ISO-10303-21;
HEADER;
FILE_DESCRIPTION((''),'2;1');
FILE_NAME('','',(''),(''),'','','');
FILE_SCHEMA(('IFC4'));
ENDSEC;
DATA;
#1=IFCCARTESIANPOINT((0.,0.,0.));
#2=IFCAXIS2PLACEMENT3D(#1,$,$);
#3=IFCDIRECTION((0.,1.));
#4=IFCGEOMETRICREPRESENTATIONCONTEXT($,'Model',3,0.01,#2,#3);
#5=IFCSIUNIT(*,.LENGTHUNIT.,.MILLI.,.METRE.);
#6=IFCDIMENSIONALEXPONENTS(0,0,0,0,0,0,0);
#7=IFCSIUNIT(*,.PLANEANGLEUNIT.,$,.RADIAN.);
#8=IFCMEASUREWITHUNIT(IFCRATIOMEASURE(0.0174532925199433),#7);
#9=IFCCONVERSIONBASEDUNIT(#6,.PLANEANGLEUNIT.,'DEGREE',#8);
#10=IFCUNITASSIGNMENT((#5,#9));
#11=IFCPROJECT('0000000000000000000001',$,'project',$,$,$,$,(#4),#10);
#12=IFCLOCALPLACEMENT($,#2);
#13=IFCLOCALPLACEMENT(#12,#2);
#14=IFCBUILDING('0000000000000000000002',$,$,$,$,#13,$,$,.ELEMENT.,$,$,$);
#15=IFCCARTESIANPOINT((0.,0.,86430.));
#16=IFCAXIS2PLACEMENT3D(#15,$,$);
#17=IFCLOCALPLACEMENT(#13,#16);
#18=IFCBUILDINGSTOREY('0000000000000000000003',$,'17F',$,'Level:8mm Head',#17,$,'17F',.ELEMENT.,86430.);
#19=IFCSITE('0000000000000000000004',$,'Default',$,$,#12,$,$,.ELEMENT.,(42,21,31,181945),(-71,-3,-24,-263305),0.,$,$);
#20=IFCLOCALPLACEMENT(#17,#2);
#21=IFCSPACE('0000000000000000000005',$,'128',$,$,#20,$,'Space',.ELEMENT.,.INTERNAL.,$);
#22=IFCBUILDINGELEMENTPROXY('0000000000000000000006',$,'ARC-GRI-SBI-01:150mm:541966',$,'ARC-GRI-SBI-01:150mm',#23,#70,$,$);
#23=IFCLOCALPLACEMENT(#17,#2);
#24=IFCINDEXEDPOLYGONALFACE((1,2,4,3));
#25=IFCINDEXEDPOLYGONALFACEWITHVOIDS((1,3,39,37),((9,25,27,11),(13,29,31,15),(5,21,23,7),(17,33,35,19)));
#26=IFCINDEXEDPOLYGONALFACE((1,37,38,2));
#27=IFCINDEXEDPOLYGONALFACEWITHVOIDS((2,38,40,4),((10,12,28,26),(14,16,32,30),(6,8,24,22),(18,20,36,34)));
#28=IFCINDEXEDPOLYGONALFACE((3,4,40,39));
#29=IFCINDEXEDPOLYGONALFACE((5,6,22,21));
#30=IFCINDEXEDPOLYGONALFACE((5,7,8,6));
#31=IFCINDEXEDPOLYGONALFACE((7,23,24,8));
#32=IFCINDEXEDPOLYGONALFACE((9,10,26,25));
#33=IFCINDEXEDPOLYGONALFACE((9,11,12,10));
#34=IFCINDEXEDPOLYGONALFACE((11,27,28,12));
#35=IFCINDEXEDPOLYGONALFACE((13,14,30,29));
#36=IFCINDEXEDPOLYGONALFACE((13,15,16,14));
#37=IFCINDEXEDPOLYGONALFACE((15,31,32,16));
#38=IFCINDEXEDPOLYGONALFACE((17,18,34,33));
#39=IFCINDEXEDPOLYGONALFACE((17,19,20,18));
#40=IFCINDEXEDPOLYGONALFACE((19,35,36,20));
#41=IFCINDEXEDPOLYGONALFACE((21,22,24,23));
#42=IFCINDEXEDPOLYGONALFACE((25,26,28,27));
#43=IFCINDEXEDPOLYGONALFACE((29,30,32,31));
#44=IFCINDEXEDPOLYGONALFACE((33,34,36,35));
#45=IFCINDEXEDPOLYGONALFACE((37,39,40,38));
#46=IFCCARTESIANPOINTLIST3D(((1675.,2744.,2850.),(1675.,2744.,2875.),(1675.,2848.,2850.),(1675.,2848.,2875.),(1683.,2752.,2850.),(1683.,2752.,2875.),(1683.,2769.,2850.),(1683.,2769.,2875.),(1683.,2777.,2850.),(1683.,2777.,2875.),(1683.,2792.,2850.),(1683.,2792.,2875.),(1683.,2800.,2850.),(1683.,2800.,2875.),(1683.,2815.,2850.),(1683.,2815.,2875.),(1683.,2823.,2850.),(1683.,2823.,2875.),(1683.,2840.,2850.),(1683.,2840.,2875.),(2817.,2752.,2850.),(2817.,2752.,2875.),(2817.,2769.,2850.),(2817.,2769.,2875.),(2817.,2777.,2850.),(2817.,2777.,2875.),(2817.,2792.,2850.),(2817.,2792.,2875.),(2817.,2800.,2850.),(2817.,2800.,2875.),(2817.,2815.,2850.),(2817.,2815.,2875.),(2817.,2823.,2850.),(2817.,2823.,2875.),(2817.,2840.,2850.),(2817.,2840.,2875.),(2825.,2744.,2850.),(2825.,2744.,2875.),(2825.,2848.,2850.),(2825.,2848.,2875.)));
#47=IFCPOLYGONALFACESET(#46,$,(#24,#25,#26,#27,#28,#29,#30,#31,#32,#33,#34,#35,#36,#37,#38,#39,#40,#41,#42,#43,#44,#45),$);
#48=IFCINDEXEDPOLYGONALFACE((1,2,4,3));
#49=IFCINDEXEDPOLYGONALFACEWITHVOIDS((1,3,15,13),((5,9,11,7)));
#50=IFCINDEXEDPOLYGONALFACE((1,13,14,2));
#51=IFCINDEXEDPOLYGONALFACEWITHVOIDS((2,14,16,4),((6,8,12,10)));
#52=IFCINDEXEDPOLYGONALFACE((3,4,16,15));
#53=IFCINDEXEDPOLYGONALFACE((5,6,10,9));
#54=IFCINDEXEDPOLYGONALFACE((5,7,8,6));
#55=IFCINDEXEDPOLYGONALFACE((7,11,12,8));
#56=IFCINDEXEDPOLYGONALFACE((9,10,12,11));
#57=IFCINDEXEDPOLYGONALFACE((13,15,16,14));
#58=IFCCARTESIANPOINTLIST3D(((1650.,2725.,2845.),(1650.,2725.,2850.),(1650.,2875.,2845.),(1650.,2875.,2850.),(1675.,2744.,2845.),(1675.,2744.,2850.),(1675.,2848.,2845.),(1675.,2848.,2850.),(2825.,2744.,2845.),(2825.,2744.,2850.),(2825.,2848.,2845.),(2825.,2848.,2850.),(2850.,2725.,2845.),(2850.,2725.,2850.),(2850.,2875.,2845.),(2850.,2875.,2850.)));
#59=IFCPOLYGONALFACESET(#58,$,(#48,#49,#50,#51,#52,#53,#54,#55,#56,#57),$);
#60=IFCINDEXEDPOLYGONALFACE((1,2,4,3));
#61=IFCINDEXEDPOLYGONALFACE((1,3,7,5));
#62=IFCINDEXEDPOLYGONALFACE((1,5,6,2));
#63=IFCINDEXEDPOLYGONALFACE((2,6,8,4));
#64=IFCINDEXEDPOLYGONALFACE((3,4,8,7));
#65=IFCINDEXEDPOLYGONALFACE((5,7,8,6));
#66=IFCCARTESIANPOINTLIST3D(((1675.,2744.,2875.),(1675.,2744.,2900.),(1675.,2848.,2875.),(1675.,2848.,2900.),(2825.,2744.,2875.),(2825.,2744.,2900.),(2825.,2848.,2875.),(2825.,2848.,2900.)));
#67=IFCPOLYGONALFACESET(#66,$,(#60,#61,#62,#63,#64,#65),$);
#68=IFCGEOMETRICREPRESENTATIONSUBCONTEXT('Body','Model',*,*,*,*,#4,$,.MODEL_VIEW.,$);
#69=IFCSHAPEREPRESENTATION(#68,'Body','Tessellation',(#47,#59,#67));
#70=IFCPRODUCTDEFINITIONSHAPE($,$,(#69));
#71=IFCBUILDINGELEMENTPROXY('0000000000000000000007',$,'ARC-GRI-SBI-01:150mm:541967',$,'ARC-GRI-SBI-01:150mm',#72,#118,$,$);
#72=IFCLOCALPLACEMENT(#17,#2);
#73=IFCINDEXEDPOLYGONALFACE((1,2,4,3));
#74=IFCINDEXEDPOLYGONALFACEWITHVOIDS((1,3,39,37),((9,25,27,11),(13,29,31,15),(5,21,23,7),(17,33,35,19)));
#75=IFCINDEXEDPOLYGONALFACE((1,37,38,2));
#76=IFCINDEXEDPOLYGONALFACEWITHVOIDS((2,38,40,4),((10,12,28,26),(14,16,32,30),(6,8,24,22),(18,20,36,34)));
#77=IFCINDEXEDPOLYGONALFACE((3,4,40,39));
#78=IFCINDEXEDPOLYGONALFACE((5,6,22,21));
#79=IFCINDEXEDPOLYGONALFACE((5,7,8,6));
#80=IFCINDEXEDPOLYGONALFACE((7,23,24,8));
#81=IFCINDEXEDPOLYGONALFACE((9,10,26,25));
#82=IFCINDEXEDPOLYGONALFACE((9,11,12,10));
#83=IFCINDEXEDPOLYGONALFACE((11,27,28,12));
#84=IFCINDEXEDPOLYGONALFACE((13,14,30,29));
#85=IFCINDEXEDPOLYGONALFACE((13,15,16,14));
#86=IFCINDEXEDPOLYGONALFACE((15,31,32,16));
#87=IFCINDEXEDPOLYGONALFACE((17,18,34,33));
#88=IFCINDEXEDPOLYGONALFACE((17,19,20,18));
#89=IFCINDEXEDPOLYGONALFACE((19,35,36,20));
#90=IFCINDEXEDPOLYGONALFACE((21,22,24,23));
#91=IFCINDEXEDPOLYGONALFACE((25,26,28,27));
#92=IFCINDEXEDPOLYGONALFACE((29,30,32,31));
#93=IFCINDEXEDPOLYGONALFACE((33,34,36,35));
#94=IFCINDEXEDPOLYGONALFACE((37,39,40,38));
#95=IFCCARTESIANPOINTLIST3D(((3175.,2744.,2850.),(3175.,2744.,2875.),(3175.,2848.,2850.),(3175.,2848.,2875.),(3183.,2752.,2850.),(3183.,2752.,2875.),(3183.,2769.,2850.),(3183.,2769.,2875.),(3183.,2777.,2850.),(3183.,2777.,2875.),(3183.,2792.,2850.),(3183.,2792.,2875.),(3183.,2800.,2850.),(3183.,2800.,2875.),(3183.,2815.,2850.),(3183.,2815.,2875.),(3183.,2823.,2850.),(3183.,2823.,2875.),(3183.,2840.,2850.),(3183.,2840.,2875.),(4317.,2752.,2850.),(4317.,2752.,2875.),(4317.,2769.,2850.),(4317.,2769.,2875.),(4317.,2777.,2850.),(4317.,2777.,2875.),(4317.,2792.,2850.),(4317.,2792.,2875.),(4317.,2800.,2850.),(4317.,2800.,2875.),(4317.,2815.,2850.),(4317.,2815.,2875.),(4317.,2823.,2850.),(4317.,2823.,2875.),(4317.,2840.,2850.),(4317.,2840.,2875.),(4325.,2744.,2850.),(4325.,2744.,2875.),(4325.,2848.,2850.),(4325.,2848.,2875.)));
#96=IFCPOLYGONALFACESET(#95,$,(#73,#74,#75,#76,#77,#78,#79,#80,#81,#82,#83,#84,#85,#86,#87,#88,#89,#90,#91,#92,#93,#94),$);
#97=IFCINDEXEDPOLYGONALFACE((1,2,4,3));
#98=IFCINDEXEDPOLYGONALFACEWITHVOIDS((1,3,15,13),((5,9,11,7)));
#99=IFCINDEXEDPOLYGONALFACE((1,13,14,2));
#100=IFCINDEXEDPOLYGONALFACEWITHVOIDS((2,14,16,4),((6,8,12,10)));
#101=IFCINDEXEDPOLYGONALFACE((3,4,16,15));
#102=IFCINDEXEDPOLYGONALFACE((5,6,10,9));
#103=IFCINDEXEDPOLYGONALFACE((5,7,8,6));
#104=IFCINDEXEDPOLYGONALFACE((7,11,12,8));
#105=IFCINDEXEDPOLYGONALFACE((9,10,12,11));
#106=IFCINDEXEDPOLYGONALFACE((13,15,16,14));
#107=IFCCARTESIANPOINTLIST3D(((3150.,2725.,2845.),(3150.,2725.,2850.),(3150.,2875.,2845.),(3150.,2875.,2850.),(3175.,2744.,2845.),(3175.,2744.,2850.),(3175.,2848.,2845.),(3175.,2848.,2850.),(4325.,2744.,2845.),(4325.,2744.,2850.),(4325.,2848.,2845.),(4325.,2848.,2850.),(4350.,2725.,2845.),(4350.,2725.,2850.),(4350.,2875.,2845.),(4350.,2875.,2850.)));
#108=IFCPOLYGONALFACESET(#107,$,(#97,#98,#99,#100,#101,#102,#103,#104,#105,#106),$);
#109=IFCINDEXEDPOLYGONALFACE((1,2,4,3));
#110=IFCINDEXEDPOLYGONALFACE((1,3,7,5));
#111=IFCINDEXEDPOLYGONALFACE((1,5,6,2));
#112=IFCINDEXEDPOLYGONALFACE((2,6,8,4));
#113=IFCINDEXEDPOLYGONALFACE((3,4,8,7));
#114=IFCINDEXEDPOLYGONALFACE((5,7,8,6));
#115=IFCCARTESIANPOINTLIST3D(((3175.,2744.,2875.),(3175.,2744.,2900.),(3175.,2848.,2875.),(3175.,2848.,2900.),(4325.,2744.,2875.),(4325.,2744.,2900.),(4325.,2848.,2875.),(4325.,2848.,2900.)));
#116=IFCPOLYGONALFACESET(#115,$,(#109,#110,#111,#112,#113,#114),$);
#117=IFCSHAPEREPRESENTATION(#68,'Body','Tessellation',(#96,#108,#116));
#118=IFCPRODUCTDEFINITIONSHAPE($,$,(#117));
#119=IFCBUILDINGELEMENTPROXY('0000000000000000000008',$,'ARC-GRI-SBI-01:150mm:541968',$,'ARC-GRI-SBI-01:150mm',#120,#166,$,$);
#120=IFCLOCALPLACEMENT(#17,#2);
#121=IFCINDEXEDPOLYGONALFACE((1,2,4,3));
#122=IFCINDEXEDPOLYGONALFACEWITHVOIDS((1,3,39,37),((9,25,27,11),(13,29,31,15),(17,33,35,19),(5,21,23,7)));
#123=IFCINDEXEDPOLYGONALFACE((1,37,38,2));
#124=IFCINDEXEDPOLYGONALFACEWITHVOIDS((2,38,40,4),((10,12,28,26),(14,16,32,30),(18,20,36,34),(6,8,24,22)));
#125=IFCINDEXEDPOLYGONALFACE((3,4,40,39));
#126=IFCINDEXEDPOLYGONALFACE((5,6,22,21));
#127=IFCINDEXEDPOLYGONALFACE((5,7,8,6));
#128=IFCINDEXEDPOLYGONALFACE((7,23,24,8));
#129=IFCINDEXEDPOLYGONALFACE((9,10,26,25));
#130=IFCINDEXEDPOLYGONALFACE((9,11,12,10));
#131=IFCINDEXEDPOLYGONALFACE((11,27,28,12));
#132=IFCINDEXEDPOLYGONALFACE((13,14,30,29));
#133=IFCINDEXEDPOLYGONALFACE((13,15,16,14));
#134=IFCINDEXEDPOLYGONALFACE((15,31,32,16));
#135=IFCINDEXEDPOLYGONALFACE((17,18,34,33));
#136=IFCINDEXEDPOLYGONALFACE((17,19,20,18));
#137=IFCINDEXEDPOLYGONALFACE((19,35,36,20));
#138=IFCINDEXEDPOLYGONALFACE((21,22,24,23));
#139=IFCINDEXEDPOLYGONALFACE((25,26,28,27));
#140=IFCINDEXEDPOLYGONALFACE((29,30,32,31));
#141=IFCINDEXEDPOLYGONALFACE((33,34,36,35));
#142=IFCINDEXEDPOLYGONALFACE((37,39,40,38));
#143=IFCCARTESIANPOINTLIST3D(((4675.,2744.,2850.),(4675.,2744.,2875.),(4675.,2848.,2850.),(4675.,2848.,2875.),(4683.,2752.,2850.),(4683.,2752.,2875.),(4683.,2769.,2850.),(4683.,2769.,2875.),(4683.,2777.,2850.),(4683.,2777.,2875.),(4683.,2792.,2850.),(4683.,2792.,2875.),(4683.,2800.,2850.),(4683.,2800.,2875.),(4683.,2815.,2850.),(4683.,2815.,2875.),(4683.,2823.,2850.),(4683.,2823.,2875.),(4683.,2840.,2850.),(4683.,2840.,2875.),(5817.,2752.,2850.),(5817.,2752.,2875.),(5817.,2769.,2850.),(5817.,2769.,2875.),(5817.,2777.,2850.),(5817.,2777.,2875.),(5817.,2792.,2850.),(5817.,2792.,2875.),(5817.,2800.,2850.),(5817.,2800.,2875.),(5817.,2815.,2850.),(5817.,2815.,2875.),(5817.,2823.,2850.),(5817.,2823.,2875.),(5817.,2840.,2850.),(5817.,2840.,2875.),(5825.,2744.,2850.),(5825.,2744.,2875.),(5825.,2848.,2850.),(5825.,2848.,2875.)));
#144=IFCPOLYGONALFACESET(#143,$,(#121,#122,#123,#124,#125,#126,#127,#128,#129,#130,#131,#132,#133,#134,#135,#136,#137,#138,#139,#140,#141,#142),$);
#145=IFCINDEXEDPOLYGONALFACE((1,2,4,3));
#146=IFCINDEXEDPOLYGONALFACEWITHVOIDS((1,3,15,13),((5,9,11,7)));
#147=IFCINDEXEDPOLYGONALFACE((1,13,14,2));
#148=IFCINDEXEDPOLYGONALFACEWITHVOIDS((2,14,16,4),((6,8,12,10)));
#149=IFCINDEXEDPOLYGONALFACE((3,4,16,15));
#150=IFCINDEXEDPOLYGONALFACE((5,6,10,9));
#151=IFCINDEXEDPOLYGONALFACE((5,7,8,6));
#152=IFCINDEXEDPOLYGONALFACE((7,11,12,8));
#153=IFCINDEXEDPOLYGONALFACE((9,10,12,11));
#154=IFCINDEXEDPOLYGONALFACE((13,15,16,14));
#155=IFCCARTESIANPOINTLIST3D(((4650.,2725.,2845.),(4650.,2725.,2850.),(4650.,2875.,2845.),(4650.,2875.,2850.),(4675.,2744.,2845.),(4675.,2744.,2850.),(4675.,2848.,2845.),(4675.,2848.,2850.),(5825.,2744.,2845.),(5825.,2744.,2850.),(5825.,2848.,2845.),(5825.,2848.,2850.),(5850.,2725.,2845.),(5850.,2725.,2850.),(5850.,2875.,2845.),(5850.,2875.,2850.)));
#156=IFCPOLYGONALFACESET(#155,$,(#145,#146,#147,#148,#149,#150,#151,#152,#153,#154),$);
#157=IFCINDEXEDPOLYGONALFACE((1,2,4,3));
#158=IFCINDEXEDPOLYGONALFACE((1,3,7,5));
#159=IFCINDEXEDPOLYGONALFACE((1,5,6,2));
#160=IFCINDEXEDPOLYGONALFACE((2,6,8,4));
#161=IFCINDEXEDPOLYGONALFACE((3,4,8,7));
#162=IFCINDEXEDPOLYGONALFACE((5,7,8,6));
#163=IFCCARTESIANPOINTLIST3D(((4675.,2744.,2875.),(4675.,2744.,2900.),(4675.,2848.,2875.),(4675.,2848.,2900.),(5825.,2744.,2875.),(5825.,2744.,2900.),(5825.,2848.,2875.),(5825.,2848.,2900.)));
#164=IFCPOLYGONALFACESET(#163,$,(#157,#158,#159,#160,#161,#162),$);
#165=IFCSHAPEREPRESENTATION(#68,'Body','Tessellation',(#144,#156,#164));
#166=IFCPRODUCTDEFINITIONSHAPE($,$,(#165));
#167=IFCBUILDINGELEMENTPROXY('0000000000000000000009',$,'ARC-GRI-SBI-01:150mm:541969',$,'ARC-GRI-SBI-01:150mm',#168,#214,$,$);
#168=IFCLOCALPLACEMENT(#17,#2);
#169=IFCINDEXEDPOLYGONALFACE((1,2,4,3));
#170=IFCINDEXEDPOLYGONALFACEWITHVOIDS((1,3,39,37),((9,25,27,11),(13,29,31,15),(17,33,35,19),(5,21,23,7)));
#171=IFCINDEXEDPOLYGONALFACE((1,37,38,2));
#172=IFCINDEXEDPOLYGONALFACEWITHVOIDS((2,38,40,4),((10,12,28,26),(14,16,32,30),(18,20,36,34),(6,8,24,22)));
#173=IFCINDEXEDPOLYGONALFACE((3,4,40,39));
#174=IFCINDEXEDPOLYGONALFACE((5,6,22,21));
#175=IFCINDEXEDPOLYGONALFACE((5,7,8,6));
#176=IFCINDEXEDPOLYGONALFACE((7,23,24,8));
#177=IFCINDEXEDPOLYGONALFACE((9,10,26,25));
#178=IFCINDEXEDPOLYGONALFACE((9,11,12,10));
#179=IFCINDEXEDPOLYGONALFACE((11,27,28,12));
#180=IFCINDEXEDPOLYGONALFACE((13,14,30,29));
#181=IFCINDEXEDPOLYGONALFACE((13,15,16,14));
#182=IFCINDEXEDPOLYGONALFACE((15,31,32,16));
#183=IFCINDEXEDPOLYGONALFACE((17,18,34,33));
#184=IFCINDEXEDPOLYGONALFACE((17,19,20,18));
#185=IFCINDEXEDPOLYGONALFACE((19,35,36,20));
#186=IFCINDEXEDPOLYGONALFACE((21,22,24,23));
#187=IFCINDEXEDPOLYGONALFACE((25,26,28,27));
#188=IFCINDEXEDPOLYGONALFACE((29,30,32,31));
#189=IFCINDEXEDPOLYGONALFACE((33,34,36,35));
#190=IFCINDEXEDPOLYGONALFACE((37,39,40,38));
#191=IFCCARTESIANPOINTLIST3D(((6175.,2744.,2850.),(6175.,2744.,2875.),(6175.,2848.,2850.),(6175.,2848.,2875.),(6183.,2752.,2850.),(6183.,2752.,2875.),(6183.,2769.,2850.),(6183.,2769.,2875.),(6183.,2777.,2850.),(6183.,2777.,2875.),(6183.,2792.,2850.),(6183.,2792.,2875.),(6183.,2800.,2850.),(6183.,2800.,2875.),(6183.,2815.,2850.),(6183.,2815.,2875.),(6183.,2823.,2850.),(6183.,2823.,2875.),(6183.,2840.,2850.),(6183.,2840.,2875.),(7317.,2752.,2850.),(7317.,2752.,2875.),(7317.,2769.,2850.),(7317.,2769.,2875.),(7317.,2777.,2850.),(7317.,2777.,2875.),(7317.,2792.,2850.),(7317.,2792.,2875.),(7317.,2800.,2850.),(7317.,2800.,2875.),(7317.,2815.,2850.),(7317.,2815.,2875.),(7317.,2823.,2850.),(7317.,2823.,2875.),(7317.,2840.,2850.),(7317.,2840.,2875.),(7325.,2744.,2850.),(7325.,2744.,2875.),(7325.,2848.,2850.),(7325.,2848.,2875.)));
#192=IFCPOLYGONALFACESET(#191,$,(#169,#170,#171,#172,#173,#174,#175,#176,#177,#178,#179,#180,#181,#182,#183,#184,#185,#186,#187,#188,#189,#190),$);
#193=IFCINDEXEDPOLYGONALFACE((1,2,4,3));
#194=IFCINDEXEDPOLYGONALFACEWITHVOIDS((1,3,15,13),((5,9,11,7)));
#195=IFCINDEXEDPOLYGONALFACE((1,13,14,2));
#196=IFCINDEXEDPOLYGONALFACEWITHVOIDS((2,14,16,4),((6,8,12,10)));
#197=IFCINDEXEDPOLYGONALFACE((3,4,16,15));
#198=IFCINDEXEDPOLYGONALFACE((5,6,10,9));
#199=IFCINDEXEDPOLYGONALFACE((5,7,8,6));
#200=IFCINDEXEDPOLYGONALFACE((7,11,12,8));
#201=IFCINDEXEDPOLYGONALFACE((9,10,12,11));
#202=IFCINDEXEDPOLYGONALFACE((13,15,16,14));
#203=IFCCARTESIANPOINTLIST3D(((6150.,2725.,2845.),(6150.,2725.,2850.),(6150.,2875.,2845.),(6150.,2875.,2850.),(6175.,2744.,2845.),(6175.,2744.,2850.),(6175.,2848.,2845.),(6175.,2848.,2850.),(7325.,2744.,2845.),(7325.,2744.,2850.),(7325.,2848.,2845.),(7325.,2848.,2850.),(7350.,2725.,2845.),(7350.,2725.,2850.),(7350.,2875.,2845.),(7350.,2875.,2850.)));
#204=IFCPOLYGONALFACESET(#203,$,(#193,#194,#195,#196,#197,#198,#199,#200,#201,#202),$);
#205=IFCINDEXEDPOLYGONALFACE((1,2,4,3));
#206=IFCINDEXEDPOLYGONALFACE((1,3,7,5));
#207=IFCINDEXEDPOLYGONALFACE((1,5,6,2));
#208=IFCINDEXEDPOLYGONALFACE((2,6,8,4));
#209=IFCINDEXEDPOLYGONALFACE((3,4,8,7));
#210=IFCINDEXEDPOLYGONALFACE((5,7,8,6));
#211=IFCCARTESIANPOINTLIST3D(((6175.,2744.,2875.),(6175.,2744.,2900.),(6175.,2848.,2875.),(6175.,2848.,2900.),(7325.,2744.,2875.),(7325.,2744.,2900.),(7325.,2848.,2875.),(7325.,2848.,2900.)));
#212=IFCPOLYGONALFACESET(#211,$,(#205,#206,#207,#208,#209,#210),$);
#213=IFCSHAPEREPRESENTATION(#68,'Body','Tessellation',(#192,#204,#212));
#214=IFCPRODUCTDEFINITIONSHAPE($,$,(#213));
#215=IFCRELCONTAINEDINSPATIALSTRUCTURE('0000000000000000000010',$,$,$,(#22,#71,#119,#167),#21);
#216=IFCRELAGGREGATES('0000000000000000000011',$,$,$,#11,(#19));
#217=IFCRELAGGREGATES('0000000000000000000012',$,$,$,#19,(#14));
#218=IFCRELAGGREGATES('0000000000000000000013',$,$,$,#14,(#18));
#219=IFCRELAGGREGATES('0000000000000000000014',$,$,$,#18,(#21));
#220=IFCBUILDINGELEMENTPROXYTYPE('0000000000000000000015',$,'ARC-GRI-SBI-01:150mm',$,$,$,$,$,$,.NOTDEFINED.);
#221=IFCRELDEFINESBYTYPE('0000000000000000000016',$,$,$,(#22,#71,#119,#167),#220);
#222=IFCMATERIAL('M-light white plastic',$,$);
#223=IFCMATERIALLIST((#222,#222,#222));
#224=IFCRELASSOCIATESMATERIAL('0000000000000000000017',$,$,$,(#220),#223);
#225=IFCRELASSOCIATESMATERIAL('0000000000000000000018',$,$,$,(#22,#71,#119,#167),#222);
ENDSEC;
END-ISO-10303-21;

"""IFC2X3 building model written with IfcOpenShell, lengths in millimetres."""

from ifc_helpers import new_model, entity, si_unit, converted_unit, direction, frame, origin, origin_2d_with_axis, place, context, subcontext, project, spatial, polyline, rectangle, outline, extrude, source, transform, mapped, material, material_list, type_object, type_shapes, element, save


model = new_model("IFC2X3")

# Units and contexts
model_context = context("Model", 3, precision=0.01, world=origin(), true_north=direction((0.0, 1.0)))
body_context = subcontext(model_context, "Body", "Model", "MODEL_VIEW")
ifc_project = project(units=[si_unit("LENGTHUNIT", "METRE", prefix="MILLI"), converted_unit("PLANEANGLEUNIT", "DEGREE", entity("IfcRatioMeasure", 0.0174532925199433), si_unit("PLANEANGLEUNIT", "RADIAN"), dimensions=[0, 0, 0, 0, 0, 0, 0])], contexts=[model_context])

# Site, building, storey
site_placement = place(None, origin())
site = spatial("IfcSite", under=ifc_project, at=site_placement, Name="Default", CompositionType="ELEMENT", RefLatitude=(42, 21, 31, 181945), RefLongitude=(-71, -3, -24, -263305), RefElevation=0.0)
building_placement = place(site_placement, origin())
building = spatial("IfcBuilding", under=site, at=building_placement, CompositionType="ELEMENT")
storey_placement = place(building_placement, frame((0.0, 0.0, 86430.0)))
storey = spatial("IfcBuildingStorey", under=building, at=storey_placement, Name="17F", ObjectType="Level:8mm Head", LongName="17F", CompositionType="ELEMENT", Elevation=86430.0)

# Shared definitions
space_placement = place(storey_placement, origin())
space = spatial("IfcSpace", under=storey, at=space_placement, Name="128", LongName="Space", CompositionType="ELEMENT", InteriorOrExteriorSpace="INTERNAL")

# Building element proxies
ifc_material_1 = material(Name="M-light white plastic")
ifc_material_list = material_list([ifc_material_1, ifc_material_1, ifc_material_1])
building_element_proxy_type = type_object("IfcBuildingElementProxyType", Name="ARC-GRI-SBI-01:150mm", PredefinedType="NOTDEFINED", material=ifc_material_list)
shared_shape = source(origin(), body_context, "Body", "SweptSolid", [
    extrude(outline(polyline([(-575.0, -52.0), (575.0, -52.0), (575.0, 52.0), (-575.0, 52.0), (-575.0, -52.0)]), holes=[polyline([(-567.0, -44.0), (-567.0, -27.0), (567.0, -27.0), (567.0, -44.0), (-567.0, -44.0)]), polyline([(567.0, -4.0), (567.0, -19.0), (-567.0, -19.0), (-567.0, -4.0), (567.0, -4.0)]), polyline([(-567.0, 44.0), (567.0, 44.0), (567.0, 27.0), (-567.0, 27.0), (-567.0, 44.0)]), polyline([(567.0, 4.0), (-567.0, 4.0), (-567.0, 19.0), (567.0, 19.0), (567.0, 4.0)])]), frame((425.0, 4.0, 4000.0), z_axis=(0.0, 0.0, 1.0), x_axis=(-1.0, 0.0, 0.0)), (0.0, 0.0, 1.0), 25.0),
    extrude(outline(polyline([(-600.0, -75.0), (600.0, -75.0), (600.0, 75.0), (-600.0, 75.0), (-600.0, -75.0)]), holes=[polyline([(-575.0, -56.0), (-575.0, 48.0), (575.0, 48.0), (575.0, -56.0), (-575.0, -56.0)])]), frame((425.0, 0.0, 3995.0), z_axis=(0.0, 0.0, 1.0), x_axis=(-1.0, 0.0, 0.0)), (0.0, 0.0, 1.0), 5.0),
    extrude(rectangle(XDim=1150.0, YDim=104.0, at=origin_2d_with_axis()), frame((425.0, 4.0, 4025.0), z_axis=(0.0, 0.0, 1.0), x_axis=(-1.0, 0.0, 0.0)), (0.0, 0.0, 1.0), 25.0),
])
type_shapes(building_element_proxy_type, [shared_shape])
for number, where, z_axis, x_axis, name in (
    (1, (2675.0, 2800.0, -1150.0), (0.0, 0.0, 1.0), (-1.0, 0.0, 0.0), "ARC-GRI-SBI-01:150mm:541966"),
    (2, (4175.0, 2800.0, -1150.0), (0.0, 0.0, 1.0), (-1.0, 0.0, 0.0), "ARC-GRI-SBI-01:150mm:541967"),
    (3, (5675.0, 2800.0, -1150.0), (0.0, 0.0, 1.0), (-1.0, 0.0, 0.0), "ARC-GRI-SBI-01:150mm:541968"),
    (4, (7175.0, 2800.0, -1150.0), (0.0, 0.0, 1.0), (-1.0, 0.0, 0.0), "ARC-GRI-SBI-01:150mm:541969"),
):
    element("IfcBuildingElementProxy", number, at=place(space_placement, frame(where, z_axis=z_axis, x_axis=x_axis)), inside=space, type_object=building_element_proxy_type, material=ifc_material_1, Name=name, ObjectType="ARC-GRI-SBI-01:150mm", context=body_context, shape_type="MappedRepresentation", body=[
        mapped(shared_shape, transform((0.0, 0.0, 0.0), scale=1.0)),
    ])

save(model, "model.ifc")
